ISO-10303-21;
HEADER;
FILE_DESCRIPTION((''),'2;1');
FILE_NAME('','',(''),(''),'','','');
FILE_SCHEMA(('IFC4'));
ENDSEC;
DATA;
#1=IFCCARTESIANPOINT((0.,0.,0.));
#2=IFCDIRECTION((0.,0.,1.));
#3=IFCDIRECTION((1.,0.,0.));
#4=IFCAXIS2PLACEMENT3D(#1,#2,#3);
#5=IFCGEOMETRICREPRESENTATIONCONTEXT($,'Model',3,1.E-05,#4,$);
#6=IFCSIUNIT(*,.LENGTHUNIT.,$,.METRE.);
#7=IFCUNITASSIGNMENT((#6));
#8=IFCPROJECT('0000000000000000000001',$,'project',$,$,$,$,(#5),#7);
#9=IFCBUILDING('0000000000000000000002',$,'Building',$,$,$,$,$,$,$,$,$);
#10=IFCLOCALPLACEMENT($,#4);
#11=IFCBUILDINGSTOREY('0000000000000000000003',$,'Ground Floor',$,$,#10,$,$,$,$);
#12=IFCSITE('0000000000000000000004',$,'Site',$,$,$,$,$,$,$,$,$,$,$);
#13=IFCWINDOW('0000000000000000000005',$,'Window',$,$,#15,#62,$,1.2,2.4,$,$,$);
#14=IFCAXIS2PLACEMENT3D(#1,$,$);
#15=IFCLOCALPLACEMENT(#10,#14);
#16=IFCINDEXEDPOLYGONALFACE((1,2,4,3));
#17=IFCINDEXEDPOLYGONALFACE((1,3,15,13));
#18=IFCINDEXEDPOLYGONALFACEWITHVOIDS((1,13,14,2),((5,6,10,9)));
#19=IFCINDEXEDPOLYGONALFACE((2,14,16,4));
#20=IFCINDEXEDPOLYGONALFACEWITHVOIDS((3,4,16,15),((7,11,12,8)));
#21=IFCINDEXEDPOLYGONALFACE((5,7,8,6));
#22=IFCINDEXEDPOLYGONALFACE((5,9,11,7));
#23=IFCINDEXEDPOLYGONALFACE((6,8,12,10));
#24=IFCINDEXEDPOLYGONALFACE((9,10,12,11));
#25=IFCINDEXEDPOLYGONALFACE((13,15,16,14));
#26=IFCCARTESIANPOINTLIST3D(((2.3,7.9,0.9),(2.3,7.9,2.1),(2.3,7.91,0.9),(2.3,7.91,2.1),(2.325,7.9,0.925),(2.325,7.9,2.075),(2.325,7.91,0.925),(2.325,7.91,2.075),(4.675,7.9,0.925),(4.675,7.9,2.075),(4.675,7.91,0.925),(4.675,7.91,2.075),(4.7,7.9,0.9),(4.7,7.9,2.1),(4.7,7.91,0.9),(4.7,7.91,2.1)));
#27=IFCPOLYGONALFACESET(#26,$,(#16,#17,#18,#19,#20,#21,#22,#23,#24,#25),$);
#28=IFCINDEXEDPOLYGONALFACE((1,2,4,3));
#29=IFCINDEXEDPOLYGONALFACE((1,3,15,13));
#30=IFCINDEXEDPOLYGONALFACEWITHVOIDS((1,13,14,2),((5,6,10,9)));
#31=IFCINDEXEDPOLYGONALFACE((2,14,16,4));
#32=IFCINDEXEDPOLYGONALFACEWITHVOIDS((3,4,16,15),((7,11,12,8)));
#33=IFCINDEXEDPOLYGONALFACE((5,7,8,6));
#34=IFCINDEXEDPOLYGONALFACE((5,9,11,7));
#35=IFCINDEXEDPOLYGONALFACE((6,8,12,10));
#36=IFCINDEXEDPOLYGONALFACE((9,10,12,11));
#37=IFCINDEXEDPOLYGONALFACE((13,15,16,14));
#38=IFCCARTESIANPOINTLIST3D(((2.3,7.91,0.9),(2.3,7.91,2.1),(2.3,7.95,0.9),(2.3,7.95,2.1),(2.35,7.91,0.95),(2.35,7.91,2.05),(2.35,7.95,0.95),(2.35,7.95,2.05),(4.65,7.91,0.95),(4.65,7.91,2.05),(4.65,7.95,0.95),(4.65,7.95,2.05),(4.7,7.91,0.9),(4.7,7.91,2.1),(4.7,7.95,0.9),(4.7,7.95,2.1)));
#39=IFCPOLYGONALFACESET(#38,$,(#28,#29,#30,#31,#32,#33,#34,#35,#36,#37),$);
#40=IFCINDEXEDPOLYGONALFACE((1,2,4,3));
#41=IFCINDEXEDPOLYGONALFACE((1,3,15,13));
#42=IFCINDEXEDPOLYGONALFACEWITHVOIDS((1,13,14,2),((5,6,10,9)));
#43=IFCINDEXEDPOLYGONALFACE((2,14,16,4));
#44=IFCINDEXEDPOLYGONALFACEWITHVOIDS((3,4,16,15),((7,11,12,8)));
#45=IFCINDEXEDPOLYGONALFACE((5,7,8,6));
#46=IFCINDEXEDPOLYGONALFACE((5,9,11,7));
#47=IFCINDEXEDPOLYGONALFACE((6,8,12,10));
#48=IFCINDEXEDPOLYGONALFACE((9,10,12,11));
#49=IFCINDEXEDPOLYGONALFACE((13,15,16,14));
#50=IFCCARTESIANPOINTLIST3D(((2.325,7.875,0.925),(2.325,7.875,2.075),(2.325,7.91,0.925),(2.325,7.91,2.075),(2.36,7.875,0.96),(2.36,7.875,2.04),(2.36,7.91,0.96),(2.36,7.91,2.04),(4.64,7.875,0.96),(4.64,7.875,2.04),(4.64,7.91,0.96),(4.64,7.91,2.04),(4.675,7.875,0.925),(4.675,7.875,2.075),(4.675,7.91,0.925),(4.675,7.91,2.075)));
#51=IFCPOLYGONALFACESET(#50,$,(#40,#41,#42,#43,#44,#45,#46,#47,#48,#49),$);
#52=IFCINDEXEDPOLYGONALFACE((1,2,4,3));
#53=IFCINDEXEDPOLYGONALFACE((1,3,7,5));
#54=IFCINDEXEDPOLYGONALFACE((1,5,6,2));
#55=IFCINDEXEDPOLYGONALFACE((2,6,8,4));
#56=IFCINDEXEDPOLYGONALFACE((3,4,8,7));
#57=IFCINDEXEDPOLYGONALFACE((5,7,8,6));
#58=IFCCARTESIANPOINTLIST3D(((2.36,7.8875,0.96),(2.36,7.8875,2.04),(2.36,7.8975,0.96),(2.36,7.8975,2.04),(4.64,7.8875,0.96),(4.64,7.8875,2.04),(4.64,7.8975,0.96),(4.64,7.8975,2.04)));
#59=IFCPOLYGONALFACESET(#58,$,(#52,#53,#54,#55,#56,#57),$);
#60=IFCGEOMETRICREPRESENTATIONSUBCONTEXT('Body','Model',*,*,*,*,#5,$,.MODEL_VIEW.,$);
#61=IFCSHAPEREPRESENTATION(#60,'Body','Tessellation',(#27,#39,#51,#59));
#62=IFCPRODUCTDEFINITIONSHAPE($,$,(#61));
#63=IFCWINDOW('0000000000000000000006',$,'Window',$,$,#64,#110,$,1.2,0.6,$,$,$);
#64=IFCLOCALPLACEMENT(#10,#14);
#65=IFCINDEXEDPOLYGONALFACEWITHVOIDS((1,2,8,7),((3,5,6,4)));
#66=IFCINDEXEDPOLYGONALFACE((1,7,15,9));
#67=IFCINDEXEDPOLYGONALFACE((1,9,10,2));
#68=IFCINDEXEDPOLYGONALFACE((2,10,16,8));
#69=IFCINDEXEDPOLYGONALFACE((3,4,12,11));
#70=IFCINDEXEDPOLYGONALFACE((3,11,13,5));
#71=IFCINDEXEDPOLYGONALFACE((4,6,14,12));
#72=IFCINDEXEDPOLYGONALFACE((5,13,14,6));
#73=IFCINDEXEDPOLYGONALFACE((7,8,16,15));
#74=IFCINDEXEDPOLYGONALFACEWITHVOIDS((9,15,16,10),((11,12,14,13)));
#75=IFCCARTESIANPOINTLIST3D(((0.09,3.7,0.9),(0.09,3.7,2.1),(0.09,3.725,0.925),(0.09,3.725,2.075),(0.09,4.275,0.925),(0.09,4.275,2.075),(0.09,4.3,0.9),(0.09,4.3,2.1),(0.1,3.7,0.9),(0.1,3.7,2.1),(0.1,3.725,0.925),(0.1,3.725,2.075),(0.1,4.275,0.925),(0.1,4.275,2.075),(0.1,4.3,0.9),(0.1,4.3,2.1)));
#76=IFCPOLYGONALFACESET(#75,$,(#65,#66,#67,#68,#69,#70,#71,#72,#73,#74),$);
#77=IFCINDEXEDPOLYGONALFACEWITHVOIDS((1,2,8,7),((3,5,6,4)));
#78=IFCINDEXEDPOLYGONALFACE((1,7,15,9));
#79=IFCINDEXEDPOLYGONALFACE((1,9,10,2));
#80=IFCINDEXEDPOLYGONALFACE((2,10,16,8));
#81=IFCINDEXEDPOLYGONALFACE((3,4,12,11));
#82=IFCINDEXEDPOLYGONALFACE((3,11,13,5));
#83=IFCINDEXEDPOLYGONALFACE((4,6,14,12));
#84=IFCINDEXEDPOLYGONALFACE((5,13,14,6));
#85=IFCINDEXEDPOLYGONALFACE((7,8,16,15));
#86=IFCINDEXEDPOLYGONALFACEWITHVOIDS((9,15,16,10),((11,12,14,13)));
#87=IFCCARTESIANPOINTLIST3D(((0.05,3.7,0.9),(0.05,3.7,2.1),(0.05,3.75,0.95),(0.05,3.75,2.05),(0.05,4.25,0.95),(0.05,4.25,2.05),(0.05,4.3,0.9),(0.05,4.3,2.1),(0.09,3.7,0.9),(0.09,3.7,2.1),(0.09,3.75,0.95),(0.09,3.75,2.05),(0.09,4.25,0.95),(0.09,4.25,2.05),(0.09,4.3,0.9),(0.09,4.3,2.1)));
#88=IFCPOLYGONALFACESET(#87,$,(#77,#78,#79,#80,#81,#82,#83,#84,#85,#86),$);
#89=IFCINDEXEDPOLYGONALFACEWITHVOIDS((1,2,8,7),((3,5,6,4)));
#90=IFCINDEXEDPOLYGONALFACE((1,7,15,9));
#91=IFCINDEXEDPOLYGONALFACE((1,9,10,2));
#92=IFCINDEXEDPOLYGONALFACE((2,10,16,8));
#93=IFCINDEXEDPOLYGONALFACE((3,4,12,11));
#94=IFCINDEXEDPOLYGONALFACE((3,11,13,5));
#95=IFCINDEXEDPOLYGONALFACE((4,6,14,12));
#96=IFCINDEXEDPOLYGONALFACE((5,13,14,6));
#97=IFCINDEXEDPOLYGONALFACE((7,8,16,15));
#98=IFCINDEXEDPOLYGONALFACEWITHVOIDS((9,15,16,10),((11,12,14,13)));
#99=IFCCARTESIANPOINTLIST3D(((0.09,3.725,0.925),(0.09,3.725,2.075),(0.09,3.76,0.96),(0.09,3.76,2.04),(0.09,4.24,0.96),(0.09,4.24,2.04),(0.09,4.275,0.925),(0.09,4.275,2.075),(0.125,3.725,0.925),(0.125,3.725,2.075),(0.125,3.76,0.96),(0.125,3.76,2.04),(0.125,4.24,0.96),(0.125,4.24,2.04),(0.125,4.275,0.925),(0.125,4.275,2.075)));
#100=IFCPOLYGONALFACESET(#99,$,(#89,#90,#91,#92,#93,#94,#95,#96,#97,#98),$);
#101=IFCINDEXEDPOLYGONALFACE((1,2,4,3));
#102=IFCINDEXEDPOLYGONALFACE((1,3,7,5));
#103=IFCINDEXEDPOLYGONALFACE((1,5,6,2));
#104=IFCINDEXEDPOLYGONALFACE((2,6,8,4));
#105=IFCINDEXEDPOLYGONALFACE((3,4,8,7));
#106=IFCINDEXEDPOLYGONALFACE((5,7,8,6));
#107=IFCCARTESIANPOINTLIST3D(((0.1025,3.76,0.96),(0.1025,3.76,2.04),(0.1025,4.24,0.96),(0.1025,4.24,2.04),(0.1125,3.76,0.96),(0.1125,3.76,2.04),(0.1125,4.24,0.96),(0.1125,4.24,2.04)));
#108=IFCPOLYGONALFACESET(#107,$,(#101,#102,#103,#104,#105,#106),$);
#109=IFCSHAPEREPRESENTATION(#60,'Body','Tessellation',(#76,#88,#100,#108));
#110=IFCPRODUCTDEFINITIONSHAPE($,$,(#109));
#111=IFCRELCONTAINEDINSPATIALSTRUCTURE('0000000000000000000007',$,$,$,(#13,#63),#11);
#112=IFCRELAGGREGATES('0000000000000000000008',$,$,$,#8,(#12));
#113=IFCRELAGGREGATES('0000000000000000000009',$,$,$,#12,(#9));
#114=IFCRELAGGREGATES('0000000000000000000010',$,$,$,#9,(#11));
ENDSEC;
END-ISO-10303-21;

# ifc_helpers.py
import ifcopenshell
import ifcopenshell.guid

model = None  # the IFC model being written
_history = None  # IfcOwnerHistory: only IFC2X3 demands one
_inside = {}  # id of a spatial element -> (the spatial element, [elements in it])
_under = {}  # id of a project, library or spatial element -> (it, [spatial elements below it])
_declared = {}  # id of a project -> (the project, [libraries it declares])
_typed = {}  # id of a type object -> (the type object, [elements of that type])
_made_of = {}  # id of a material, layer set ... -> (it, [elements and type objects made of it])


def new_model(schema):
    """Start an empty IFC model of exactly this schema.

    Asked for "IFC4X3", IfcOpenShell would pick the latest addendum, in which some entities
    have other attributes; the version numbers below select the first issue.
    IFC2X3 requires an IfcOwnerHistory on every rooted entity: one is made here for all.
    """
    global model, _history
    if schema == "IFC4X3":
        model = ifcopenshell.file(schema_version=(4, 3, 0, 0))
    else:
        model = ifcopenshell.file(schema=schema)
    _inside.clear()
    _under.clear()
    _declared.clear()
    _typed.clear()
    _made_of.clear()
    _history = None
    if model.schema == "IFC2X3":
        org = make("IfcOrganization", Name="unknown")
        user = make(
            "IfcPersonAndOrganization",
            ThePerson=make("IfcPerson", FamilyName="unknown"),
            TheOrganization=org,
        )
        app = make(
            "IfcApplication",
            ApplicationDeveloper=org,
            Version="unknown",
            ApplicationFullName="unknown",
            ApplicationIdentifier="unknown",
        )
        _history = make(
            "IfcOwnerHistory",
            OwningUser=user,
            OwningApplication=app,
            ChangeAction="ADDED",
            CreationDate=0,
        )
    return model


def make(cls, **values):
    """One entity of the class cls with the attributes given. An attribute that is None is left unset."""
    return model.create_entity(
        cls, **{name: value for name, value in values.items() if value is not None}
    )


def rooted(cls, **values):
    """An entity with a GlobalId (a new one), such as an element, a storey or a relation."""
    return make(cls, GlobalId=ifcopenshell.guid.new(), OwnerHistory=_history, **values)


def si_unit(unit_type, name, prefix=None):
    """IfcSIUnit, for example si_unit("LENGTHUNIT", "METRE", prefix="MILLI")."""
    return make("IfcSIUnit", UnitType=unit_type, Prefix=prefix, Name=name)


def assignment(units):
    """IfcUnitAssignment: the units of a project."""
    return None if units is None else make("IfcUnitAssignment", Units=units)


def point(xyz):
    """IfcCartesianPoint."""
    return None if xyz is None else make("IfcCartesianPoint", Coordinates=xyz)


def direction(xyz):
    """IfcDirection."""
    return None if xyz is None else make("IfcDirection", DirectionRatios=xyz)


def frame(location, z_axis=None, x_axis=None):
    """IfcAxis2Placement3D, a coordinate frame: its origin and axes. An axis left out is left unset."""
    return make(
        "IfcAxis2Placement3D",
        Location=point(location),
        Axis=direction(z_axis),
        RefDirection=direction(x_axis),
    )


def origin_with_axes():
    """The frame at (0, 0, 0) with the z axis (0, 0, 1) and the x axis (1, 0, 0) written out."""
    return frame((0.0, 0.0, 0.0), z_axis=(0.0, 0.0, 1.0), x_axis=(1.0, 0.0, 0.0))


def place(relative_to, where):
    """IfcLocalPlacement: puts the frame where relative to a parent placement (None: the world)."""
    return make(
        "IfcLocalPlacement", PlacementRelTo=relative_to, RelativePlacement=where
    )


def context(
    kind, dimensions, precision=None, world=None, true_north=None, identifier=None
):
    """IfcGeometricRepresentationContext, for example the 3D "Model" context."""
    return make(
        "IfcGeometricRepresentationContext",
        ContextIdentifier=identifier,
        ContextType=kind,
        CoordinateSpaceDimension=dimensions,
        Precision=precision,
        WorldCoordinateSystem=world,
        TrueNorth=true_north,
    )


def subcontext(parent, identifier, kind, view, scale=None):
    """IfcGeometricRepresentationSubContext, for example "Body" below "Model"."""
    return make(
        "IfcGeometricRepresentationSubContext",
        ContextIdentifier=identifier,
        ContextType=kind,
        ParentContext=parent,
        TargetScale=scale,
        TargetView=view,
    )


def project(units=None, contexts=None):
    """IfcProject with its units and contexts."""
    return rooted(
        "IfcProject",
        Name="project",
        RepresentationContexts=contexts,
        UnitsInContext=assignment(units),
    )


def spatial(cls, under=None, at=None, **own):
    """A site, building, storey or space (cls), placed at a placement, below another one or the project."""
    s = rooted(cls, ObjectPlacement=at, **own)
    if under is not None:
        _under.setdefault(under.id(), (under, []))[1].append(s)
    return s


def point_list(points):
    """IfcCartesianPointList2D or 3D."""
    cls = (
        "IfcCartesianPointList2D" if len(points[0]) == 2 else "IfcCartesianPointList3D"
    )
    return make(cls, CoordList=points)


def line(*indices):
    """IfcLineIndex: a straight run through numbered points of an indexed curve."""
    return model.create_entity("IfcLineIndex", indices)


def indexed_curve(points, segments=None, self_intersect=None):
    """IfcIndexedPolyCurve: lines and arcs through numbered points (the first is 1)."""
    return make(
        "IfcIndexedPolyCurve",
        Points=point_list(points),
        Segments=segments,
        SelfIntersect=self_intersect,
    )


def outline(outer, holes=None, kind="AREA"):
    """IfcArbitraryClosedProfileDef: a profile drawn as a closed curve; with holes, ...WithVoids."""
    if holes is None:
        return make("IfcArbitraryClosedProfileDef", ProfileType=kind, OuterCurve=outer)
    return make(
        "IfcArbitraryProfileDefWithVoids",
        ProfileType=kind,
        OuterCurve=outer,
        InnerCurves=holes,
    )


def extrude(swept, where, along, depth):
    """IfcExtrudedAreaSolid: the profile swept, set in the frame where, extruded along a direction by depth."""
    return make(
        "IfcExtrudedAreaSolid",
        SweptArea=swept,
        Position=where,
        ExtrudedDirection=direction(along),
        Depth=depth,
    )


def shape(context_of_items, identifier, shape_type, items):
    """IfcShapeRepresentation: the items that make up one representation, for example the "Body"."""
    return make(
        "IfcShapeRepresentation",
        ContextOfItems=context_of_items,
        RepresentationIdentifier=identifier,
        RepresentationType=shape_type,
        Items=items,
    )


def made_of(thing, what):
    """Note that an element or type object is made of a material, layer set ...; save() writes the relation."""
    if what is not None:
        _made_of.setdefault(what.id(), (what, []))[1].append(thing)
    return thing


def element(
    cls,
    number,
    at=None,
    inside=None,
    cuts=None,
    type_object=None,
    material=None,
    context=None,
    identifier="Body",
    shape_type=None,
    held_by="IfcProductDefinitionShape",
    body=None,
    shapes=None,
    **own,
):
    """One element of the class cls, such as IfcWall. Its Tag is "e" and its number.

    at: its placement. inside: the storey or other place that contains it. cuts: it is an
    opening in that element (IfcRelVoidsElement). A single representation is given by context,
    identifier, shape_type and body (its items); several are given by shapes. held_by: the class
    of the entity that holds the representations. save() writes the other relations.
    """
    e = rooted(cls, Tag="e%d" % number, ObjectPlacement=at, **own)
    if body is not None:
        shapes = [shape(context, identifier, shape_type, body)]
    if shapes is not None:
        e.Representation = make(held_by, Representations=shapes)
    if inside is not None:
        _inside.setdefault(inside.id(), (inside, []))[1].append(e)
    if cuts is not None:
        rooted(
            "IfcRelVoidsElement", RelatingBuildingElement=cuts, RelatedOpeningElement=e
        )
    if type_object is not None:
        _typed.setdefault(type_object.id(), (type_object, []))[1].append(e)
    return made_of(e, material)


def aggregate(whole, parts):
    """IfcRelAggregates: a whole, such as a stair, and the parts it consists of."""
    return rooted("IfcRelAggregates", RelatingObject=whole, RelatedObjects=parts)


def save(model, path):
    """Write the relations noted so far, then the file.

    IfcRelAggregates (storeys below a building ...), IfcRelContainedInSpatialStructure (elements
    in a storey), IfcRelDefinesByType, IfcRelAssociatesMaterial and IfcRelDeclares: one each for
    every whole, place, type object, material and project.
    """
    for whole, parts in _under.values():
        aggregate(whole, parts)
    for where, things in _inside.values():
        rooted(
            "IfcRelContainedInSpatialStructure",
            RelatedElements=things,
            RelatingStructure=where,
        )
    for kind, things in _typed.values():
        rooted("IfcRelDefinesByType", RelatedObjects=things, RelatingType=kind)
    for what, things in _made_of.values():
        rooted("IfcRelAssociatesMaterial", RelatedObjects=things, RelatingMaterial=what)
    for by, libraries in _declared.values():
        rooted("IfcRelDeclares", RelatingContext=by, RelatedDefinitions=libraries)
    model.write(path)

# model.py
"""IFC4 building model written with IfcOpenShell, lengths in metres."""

from ifc_helpers import new_model, si_unit, frame, origin_with_axes, place, context, subcontext, project, spatial, line, indexed_curve, outline, extrude, element, save


model = new_model("IFC4")

# Units and contexts
model_context = context("Model", 3, precision=1e-05, world=origin_with_axes())
body_context = subcontext(model_context, "Body", "Model", "MODEL_VIEW")
ifc_project = project(units=[si_unit("LENGTHUNIT", "METRE")], contexts=[model_context])

# Site, building, storey
site = spatial("IfcSite", under=ifc_project, Name="Site")
building = spatial("IfcBuilding", under=site, Name="Building")
storey_placement = place(None, origin_with_axes())
storey = spatial("IfcBuildingStorey", under=building, at=storey_placement, Name="Ground Floor")

# Windows
window_1_placement = place(storey_placement, frame((4.7, 8.0, 0.9), z_axis=(0.0, 0.0, 1.0), x_axis=(-1.0, 0.0, 0.0)))
element("IfcWindow", 1, at=window_1_placement, inside=storey, Name="Window", OverallHeight=1.2, OverallWidth=2.4, context=body_context, shape_type="SweptSolid", body=[
    extrude(outline(indexed_curve([(0.0, 0.0), (2.4, 0.0), (2.4, 1.2), (0.0, 1.2)], segments=[line(1, 2, 3, 4, 1)]), holes=[indexed_curve([(0.025, 0.025), (2.375, 0.025), (2.375, 1.175), (0.025, 1.175)], segments=[line(1, 2, 3, 4, 1)])]), frame((0.0, 0.09, 0.0), z_axis=(0.0, -1.0, 0.0), x_axis=(1.0, 0.0, 0.0)), (0.0, 0.0, -1.0), 0.01),
    extrude(outline(indexed_curve([(0.0, 0.0), (2.4, 0.0), (2.4, 1.2), (0.0, 1.2)], segments=[line(1, 2, 3, 4, 1)]), holes=[indexed_curve([(0.05, 0.05), (2.35, 0.05), (2.35, 1.15), (0.05, 1.15)], segments=[line(1, 2, 3, 4, 1)])]), frame((0.0, 0.05, 0.0), z_axis=(0.0, -1.0, 0.0), x_axis=(1.0, 0.0, 0.0)), (0.0, 0.0, -1.0), 0.04),
    extrude(outline(indexed_curve([(0.0, 0.0), (2.35, 0.0), (2.35, 1.15), (0.0, 1.15)], segments=[line(1, 2, 3, 4, 1)]), holes=[indexed_curve([(0.035, 0.035), (2.315, 0.035), (2.315, 1.115), (0.035, 1.115)], segments=[line(1, 2, 3, 4, 1)])]), frame((0.025, 0.09, 0.025), z_axis=(0.0, -1.0, 0.0), x_axis=(1.0, 0.0, 0.0)), (0.0, 0.0, -1.0), 0.035),
    extrude(outline(indexed_curve([(0.035, 0.035), (2.315, 0.035), (2.315, 1.115), (0.035, 1.115)], segments=[line(1, 2, 3, 4, 1)])), frame((0.025, 0.1025, 0.025), z_axis=(0.0, -1.0, 0.0), x_axis=(1.0, 0.0, 0.0)), (0.0, 0.0, -1.0), 0.01),
])
window_2_placement = place(storey_placement, frame((0.0, 4.3, 0.9), z_axis=(0.0, 0.0, 1.0), x_axis=(0.0, -1.0, 0.0)))
element("IfcWindow", 2, at=window_2_placement, inside=storey, Name="Window", OverallHeight=1.2, OverallWidth=0.6, context=body_context, shape_type="SweptSolid", body=[
    extrude(outline(indexed_curve([(0.0, 0.0), (0.6, 0.0), (0.6, 1.2), (0.0, 1.2)], segments=[line(1, 2, 3, 4, 1)]), holes=[indexed_curve([(0.025, 0.025), (0.575, 0.025), (0.575, 1.175), (0.025, 1.175)], segments=[line(1, 2, 3, 4, 1)])]), frame((0.0, 0.09, 0.0), z_axis=(0.0, -1.0, 0.0), x_axis=(1.0, 0.0, 0.0)), (0.0, 0.0, -1.0), 0.01),
    extrude(outline(indexed_curve([(0.0, 0.0), (0.6, 0.0), (0.6, 1.2), (0.0, 1.2)], segments=[line(1, 2, 3, 4, 1)]), holes=[indexed_curve([(0.05, 0.05), (0.55, 0.05), (0.55, 1.15), (0.05, 1.15)], segments=[line(1, 2, 3, 4, 1)])]), frame((0.0, 0.05, 0.0), z_axis=(0.0, -1.0, 0.0), x_axis=(1.0, 0.0, 0.0)), (0.0, 0.0, -1.0), 0.04),
    extrude(outline(indexed_curve([(0.0, 0.0), (0.55, 0.0), (0.55, 1.15), (0.0, 1.15)], segments=[line(1, 2, 3, 4, 1)]), holes=[indexed_curve([(0.035, 0.035), (0.515, 0.035), (0.515, 1.115), (0.035, 1.115)], segments=[line(1, 2, 3, 4, 1)])]), frame((0.025, 0.09, 0.025), z_axis=(0.0, -1.0, 0.0), x_axis=(1.0, 0.0, 0.0)), (0.0, 0.0, -1.0), 0.035),
    extrude(outline(indexed_curve([(0.035, 0.035), (0.515, 0.035), (0.515, 1.115), (0.035, 1.115)], segments=[line(1, 2, 3, 4, 1)])), frame((0.025, 0.1025, 0.025), z_axis=(0.0, -1.0, 0.0), x_axis=(1.0, 0.0, 0.0)), (0.0, 0.0, -1.0), 0.01),
])

save(model, "model.ifc")
